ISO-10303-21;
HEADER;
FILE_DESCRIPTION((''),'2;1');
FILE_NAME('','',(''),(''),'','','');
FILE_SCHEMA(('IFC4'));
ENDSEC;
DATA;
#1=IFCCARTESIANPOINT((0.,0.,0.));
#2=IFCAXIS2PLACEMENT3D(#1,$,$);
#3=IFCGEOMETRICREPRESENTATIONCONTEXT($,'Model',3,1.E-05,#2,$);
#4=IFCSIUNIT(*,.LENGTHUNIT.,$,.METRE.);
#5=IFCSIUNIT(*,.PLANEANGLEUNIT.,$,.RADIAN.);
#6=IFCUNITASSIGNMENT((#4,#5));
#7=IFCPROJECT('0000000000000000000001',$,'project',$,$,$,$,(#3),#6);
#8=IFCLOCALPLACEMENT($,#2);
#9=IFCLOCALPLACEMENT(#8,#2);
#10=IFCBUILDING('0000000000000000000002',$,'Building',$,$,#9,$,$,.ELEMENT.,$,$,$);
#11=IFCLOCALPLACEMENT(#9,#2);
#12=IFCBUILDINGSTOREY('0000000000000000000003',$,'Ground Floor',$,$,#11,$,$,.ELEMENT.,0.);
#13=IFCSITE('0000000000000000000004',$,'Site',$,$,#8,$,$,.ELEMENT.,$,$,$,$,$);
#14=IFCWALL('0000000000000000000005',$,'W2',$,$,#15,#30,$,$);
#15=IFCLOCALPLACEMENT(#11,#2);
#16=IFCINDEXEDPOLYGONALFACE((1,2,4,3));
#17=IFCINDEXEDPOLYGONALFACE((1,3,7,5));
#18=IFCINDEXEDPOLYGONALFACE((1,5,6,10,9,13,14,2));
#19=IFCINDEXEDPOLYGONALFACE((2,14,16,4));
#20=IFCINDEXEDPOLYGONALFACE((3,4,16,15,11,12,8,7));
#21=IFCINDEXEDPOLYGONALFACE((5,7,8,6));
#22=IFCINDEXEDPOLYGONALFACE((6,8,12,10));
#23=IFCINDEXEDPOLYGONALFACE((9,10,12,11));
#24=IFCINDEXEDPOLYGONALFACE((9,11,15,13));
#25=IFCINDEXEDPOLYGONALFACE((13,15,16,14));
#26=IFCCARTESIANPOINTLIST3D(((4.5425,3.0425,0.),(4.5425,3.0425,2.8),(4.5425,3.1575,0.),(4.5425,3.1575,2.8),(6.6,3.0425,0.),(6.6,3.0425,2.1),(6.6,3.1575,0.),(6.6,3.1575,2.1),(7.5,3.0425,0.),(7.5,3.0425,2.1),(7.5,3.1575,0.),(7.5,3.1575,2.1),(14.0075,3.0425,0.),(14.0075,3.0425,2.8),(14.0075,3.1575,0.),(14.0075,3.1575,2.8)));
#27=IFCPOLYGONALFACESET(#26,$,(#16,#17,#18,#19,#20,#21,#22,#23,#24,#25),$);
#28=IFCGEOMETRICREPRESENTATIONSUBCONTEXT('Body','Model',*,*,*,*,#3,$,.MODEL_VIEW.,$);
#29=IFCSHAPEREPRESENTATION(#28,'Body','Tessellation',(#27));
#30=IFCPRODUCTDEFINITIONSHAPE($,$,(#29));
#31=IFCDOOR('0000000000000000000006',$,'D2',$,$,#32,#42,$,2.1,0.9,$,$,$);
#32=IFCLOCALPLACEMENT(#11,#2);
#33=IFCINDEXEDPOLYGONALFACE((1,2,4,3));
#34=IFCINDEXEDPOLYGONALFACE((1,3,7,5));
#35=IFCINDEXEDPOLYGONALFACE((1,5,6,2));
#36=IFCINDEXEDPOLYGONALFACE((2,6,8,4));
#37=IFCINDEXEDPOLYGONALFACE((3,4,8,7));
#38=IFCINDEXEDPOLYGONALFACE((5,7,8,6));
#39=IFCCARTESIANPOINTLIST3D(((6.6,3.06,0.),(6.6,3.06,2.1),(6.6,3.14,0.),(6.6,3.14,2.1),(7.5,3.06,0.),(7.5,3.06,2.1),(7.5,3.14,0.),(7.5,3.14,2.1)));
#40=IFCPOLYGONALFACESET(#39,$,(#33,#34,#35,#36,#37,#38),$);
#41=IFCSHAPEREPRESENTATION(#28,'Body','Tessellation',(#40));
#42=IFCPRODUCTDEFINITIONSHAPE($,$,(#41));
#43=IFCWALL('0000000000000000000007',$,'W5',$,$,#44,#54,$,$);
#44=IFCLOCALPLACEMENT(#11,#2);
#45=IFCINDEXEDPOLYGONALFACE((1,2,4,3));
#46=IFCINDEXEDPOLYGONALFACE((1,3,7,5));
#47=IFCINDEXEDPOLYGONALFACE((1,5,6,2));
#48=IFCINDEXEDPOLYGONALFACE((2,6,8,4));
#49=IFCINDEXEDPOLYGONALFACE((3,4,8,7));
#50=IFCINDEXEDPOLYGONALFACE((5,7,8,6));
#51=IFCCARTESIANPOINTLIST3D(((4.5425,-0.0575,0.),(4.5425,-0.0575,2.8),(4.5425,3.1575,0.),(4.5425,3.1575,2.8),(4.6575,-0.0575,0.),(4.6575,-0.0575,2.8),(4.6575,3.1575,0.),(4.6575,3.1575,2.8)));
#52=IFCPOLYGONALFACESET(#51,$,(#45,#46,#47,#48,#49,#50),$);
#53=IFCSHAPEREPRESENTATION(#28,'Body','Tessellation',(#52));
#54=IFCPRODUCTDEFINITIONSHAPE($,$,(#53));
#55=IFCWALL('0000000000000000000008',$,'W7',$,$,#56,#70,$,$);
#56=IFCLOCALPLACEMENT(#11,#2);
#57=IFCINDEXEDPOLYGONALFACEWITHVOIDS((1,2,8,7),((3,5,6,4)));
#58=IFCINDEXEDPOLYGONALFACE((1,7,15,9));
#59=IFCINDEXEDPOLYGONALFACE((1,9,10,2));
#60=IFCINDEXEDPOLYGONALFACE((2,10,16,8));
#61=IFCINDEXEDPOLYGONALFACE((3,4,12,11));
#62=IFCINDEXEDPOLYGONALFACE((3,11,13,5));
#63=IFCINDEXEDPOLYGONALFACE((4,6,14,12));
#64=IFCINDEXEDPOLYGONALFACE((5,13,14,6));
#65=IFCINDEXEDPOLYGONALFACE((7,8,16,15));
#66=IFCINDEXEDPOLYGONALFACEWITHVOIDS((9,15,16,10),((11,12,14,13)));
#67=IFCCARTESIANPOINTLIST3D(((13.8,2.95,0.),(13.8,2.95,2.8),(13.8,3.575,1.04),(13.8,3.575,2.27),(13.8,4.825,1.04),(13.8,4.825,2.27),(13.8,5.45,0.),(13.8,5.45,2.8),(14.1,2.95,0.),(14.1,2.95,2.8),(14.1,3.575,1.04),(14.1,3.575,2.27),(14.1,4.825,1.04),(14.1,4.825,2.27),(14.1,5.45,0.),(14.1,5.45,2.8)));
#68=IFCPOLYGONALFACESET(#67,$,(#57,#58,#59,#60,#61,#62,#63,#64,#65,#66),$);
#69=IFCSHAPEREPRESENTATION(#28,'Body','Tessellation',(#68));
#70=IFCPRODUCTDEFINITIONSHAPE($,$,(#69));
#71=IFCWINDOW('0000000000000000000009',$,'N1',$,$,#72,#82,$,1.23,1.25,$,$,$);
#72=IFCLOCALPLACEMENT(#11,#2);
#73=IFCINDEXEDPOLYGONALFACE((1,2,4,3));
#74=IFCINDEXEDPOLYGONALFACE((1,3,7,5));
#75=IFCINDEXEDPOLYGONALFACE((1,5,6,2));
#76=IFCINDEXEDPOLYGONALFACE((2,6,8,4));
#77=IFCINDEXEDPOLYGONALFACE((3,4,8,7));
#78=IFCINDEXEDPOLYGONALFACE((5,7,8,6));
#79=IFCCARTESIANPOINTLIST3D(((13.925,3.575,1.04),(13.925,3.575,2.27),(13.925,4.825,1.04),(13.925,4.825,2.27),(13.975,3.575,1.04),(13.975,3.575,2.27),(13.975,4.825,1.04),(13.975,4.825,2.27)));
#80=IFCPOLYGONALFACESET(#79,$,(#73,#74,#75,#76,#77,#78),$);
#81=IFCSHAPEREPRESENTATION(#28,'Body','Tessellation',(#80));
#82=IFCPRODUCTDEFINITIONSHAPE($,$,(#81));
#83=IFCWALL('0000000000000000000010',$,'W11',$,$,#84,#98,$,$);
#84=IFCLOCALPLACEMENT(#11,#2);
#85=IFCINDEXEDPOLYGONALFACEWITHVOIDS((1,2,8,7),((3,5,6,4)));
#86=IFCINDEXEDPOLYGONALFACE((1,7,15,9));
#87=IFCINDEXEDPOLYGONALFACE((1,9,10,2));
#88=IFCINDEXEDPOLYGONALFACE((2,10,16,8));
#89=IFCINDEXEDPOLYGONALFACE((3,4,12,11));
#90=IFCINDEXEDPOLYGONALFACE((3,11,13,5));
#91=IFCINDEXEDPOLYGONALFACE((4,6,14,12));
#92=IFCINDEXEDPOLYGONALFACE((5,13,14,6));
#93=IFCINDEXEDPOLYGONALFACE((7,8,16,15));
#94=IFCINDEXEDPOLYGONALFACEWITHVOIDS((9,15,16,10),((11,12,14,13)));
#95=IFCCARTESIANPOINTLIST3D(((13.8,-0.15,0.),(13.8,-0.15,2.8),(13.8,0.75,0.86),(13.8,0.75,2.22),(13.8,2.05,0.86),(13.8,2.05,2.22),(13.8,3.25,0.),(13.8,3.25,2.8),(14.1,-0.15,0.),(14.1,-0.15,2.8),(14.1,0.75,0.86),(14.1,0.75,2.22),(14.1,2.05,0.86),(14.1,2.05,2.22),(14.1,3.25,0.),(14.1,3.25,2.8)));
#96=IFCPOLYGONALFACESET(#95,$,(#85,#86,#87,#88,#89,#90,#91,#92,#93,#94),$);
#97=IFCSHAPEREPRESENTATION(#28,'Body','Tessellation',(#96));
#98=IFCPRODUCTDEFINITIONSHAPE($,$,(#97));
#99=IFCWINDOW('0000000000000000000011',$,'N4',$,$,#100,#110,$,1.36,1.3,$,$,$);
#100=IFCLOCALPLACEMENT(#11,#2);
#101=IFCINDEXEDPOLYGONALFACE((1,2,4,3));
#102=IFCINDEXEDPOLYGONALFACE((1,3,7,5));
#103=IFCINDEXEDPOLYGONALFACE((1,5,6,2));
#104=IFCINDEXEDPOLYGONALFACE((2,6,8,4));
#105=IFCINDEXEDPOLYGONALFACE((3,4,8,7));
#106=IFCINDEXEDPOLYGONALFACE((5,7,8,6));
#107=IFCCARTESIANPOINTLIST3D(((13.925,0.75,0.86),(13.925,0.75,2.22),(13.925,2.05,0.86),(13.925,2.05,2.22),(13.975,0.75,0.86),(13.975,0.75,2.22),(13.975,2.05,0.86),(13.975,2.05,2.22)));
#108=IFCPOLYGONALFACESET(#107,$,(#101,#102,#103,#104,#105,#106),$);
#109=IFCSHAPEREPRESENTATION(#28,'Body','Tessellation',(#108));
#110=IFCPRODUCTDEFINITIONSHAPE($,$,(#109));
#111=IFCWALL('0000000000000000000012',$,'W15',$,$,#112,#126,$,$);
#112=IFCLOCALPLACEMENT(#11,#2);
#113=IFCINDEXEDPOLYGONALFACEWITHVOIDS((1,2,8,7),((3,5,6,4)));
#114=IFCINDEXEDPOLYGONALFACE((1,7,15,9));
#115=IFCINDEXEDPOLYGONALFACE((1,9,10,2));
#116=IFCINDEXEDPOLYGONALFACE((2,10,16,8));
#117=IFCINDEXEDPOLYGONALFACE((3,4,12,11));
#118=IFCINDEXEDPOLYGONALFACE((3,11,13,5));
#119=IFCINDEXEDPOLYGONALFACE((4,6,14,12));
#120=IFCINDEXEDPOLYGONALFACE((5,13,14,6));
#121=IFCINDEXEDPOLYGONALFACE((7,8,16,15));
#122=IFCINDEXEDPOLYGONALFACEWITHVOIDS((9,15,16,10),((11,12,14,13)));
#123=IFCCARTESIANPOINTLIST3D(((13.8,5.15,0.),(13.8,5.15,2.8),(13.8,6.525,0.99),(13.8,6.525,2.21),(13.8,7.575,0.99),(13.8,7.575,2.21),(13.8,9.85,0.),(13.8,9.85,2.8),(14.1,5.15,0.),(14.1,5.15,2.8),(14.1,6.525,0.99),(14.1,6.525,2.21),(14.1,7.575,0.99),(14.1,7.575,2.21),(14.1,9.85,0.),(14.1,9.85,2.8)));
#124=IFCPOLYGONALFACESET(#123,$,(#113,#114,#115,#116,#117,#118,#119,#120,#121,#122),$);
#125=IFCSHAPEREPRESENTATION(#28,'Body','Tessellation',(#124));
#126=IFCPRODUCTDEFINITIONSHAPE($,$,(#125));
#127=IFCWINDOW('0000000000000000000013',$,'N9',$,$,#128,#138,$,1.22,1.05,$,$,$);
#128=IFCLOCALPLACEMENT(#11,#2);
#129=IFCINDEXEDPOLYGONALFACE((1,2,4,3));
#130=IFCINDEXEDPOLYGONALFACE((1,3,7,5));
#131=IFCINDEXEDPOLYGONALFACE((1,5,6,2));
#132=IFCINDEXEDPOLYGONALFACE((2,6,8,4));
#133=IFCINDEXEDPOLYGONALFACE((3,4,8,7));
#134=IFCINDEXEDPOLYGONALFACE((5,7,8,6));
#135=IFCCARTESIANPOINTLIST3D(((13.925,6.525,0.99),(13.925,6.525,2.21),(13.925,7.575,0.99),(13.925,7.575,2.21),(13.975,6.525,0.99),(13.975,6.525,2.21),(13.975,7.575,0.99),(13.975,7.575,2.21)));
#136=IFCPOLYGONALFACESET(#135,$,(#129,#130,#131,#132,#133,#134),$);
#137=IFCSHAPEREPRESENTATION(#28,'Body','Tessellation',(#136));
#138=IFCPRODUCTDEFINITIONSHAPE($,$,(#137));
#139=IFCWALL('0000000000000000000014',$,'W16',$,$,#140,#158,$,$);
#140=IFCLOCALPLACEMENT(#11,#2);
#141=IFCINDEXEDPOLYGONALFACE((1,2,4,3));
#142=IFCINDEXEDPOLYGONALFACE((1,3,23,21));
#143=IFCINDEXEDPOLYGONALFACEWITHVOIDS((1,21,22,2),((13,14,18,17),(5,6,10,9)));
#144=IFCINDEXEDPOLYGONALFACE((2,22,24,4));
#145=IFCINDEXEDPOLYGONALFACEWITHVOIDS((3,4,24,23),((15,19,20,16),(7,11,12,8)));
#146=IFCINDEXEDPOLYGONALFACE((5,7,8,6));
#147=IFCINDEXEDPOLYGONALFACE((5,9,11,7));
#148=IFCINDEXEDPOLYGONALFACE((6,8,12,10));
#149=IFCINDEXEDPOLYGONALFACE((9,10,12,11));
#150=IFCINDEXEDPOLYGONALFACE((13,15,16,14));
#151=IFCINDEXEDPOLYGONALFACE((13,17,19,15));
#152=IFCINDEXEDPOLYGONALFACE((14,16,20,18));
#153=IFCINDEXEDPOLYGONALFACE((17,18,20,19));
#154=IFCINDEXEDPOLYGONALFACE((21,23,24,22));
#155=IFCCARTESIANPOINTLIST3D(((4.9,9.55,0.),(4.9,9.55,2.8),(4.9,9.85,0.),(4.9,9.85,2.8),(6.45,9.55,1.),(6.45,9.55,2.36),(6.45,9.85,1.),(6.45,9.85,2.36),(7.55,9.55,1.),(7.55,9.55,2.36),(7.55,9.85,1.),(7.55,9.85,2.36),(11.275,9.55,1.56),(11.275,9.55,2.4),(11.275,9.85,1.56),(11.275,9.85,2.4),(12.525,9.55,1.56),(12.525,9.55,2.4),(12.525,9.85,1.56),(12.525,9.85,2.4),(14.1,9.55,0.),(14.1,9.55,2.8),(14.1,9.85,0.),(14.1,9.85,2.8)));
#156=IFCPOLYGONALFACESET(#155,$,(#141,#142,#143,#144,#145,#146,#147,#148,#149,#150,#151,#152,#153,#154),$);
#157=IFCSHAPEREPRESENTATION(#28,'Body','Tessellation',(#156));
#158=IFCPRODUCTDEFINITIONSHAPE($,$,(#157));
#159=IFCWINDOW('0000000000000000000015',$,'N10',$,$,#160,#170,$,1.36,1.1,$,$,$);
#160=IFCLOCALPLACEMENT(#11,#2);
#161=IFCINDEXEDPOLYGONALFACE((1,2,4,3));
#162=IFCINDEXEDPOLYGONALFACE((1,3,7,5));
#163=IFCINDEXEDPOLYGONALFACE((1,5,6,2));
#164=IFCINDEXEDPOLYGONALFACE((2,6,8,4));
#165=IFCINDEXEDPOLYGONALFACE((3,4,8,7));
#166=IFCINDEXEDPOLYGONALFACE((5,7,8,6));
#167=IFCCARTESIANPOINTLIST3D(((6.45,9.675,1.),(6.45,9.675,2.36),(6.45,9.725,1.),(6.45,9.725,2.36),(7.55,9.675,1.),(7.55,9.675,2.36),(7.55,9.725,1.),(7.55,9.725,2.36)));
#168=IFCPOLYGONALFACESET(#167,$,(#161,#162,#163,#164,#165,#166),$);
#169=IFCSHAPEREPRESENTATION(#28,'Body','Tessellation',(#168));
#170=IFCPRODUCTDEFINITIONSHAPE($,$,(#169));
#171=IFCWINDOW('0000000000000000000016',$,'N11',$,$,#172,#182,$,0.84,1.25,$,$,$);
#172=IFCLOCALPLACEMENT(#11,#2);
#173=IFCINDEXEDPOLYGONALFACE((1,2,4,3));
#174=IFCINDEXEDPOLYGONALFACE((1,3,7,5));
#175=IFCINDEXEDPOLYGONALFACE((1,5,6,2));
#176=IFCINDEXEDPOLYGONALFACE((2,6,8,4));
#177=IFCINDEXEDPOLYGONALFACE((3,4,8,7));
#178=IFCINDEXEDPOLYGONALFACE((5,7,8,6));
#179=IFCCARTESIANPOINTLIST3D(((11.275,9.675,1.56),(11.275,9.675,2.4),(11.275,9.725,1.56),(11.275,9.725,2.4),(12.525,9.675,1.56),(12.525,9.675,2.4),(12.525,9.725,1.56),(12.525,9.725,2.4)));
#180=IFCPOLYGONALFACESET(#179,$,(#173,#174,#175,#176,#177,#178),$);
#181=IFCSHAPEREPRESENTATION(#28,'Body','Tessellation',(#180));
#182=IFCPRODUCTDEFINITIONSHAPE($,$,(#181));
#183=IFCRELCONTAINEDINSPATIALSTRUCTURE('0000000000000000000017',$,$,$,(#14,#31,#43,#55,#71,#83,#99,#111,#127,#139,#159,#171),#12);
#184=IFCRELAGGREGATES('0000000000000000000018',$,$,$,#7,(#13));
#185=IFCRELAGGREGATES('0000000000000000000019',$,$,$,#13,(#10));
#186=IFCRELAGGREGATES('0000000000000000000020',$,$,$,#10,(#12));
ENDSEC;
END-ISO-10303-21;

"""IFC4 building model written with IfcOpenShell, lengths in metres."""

from ifc_helpers import new_model, si_unit, frame, frame_2d, origin, origin_2d, place, context, subcontext, project, spatial, rectangle, extrude, element, fill, save


model = new_model("IFC4")

# Units and contexts
model_context = context("Model", 3, precision=1e-05, world=origin())
body_context = subcontext(model_context, "Body", "Model", "MODEL_VIEW")
ifc_project = project(units=[si_unit("LENGTHUNIT", "METRE"), si_unit("PLANEANGLEUNIT", "RADIAN")], contexts=[model_context])

# Site, building, storey
site_placement = place(None, origin())
site = spatial("IfcSite", under=ifc_project, at=site_placement, Name="Site", CompositionType="ELEMENT")
building_placement = place(site_placement, origin())
building = spatial("IfcBuilding", under=site, at=building_placement, Name="Building", CompositionType="ELEMENT")
storey_placement = place(building_placement, origin())
storey = spatial("IfcBuildingStorey", under=building, at=storey_placement, Name="Ground Floor", CompositionType="ELEMENT", Elevation=0.0)

# Wall, opening, door
wall_1_placement = place(storey_placement, frame((4.6, 3.1, 0.0), x_axis=(1.0, 0.0, 0.0)))
wall_1 = element("IfcWall", 1, at=wall_1_placement, inside=storey, Name="W2", context=body_context, shape_type="SweptSolid", body=[
    extrude(rectangle(XDim=9.465, YDim=0.115, at=frame_2d((4.675, 0.0))), origin(), (0.0, 0.0, 1.0), 2.8),
])
opening_1_placement = place(wall_1_placement, frame((2.45, 0.0, 0.0)))
opening_1 = element("IfcOpeningElement", 2, at=opening_1_placement, cuts=wall_1, context=body_context, shape_type="SweptSolid", body=[
    extrude(rectangle(XDim=0.9, YDim=0.215, at=origin_2d()), origin(), (0.0, 0.0, 1.0), 2.1),
])
door_1_placement = place(opening_1_placement, origin())
door_1 = element("IfcDoor", 3, at=door_1_placement, inside=storey, Name="D2", OverallHeight=2.1, OverallWidth=0.9, context=body_context, shape_type="SweptSolid", body=[
    extrude(rectangle(XDim=0.9, YDim=0.08, at=origin_2d()), origin(), (0.0, 0.0, 1.0), 2.1),
])
fill(opening_1, door_1)

# Wall
wall_2_placement = place(storey_placement, frame((4.6, 0.0, 0.0), x_axis=(0.0, 1.0, 0.0)))
element("IfcWall", 4, at=wall_2_placement, inside=storey, Name="W5", context=body_context, shape_type="SweptSolid", body=[
    extrude(rectangle(XDim=3.215, YDim=0.115, at=frame_2d((1.55, 0.0))), origin(), (0.0, 0.0, 1.0), 2.8),
])

# Walls, openings, windows
wall_3_placement = place(storey_placement, frame((13.95, 3.1, 0.0), x_axis=(0.0, 1.0, 0.0)))
wall_3 = element("IfcWall", 5, at=wall_3_placement, inside=storey, Name="W7", context=body_context, shape_type="SweptSolid", body=[
    extrude(rectangle(XDim=2.5, YDim=0.3, at=frame_2d((1.1, 0.0))), origin(), (0.0, 0.0, 1.0), 2.8),
])
opening_2_placement = place(wall_3_placement, frame((1.1, 0.0, 1.04)))
opening_2 = element("IfcOpeningElement", 6, at=opening_2_placement, cuts=wall_3, context=body_context, shape_type="SweptSolid", body=[
    extrude(rectangle(XDim=1.25, YDim=0.4, at=origin_2d()), origin(), (0.0, 0.0, 1.0), 1.23),
])
window_1_placement = place(opening_2_placement, origin())
window_1 = element("IfcWindow", 7, at=window_1_placement, inside=storey, Name="N1", OverallHeight=1.23, OverallWidth=1.25, context=body_context, shape_type="SweptSolid", body=[
    extrude(rectangle(XDim=1.25, YDim=0.05, at=origin_2d()), origin(), (0.0, 0.0, 1.0), 1.23),
])
fill(opening_2, window_1)
wall_4_placement = place(storey_placement, frame((13.95, 0.0, 0.0), x_axis=(0.0, 1.0, 0.0)))
wall_4 = element("IfcWall", 8, at=wall_4_placement, inside=storey, Name="W11", context=body_context, shape_type="SweptSolid", body=[
    extrude(rectangle(XDim=3.4, YDim=0.3, at=frame_2d((1.55, 0.0))), origin(), (0.0, 0.0, 1.0), 2.8),
])
opening_3_placement = place(wall_4_placement, frame((1.4, 0.0, 0.86)))
opening_3 = element("IfcOpeningElement", 9, at=opening_3_placement, cuts=wall_4, context=body_context, shape_type="SweptSolid", body=[
    extrude(rectangle(XDim=1.3, YDim=0.4, at=origin_2d()), origin(), (0.0, 0.0, 1.0), 1.36),
])
window_2_placement = place(opening_3_placement, origin())
window_2 = element("IfcWindow", 10, at=window_2_placement, inside=storey, Name="N4", OverallHeight=1.36, OverallWidth=1.3, context=body_context, shape_type="SweptSolid", body=[
    extrude(rectangle(XDim=1.3, YDim=0.05, at=origin_2d()), origin(), (0.0, 0.0, 1.0), 1.36),
])
fill(opening_3, window_2)

# Wall, opening, window
wall_5_placement = place(storey_placement, frame((13.95, 5.3, 0.0), x_axis=(0.0, 1.0, 0.0)))
wall_5 = element("IfcWall", 11, at=wall_5_placement, inside=storey, Name="W15", context=body_context, shape_type="SweptSolid", body=[
    extrude(rectangle(XDim=4.7, YDim=0.3, at=frame_2d((2.2, 0.0))), origin(), (0.0, 0.0, 1.0), 2.8),
])
opening_4_placement = place(wall_5_placement, frame((1.75, 0.0, 0.99)))
opening_4 = element("IfcOpeningElement", 12, at=opening_4_placement, cuts=wall_5, context=body_context, shape_type="SweptSolid", body=[
    extrude(rectangle(XDim=1.05, YDim=0.4, at=origin_2d()), origin(), (0.0, 0.0, 1.0), 1.22),
])
window_3_placement = place(opening_4_placement, origin())
window_3 = element("IfcWindow", 13, at=window_3_placement, inside=storey, Name="N9", OverallHeight=1.22, OverallWidth=1.05, context=body_context, shape_type="SweptSolid", body=[
    extrude(rectangle(XDim=1.05, YDim=0.05, at=origin_2d()), origin(), (0.0, 0.0, 1.0), 1.22),
])
fill(opening_4, window_3)

# Wall, openings, windows
wall_6_placement = place(storey_placement, frame((5.05, 9.7, 0.0), x_axis=(1.0, 0.0, 0.0)))
wall_6 = element("IfcWall", 14, at=wall_6_placement, inside=storey, Name="W16", context=body_context, shape_type="SweptSolid", body=[
    extrude(rectangle(XDim=9.2, YDim=0.3, at=frame_2d((4.45, 0.0))), origin(), (0.0, 0.0, 1.0), 2.8),
])
opening_5_placement = place(wall_6_placement, frame((1.95, 0.0, 1.0)))
opening_5 = element("IfcOpeningElement", 15, at=opening_5_placement, cuts=wall_6, context=body_context, shape_type="SweptSolid", body=[
    extrude(rectangle(XDim=1.1, YDim=0.4, at=origin_2d()), origin(), (0.0, 0.0, 1.0), 1.36),
])
opening_6_placement = place(wall_6_placement, frame((6.85, 0.0, 1.56)))
opening_6 = element("IfcOpeningElement", 16, at=opening_6_placement, cuts=wall_6, context=body_context, shape_type="SweptSolid", body=[
    extrude(rectangle(XDim=1.25, YDim=0.4, at=origin_2d()), origin(), (0.0, 0.0, 1.0), 0.84),
])
window_4_placement = place(opening_5_placement, origin())
window_4 = element("IfcWindow", 17, at=window_4_placement, inside=storey, Name="N10", OverallHeight=1.36, OverallWidth=1.1, context=body_context, shape_type="SweptSolid", body=[
    extrude(rectangle(XDim=1.1, YDim=0.05, at=origin_2d()), origin(), (0.0, 0.0, 1.0), 1.36),
])
fill(opening_5, window_4)
window_5_placement = place(opening_6_placement, origin())
window_5 = element("IfcWindow", 18, at=window_5_placement, inside=storey, Name="N11", OverallHeight=0.84, OverallWidth=1.25, context=body_context, shape_type="SweptSolid", body=[
    extrude(rectangle(XDim=1.25, YDim=0.05, at=origin_2d()), origin(), (0.0, 0.0, 1.0), 0.84),
])
fill(opening_6, window_5)

save(model, "model.ifc")
